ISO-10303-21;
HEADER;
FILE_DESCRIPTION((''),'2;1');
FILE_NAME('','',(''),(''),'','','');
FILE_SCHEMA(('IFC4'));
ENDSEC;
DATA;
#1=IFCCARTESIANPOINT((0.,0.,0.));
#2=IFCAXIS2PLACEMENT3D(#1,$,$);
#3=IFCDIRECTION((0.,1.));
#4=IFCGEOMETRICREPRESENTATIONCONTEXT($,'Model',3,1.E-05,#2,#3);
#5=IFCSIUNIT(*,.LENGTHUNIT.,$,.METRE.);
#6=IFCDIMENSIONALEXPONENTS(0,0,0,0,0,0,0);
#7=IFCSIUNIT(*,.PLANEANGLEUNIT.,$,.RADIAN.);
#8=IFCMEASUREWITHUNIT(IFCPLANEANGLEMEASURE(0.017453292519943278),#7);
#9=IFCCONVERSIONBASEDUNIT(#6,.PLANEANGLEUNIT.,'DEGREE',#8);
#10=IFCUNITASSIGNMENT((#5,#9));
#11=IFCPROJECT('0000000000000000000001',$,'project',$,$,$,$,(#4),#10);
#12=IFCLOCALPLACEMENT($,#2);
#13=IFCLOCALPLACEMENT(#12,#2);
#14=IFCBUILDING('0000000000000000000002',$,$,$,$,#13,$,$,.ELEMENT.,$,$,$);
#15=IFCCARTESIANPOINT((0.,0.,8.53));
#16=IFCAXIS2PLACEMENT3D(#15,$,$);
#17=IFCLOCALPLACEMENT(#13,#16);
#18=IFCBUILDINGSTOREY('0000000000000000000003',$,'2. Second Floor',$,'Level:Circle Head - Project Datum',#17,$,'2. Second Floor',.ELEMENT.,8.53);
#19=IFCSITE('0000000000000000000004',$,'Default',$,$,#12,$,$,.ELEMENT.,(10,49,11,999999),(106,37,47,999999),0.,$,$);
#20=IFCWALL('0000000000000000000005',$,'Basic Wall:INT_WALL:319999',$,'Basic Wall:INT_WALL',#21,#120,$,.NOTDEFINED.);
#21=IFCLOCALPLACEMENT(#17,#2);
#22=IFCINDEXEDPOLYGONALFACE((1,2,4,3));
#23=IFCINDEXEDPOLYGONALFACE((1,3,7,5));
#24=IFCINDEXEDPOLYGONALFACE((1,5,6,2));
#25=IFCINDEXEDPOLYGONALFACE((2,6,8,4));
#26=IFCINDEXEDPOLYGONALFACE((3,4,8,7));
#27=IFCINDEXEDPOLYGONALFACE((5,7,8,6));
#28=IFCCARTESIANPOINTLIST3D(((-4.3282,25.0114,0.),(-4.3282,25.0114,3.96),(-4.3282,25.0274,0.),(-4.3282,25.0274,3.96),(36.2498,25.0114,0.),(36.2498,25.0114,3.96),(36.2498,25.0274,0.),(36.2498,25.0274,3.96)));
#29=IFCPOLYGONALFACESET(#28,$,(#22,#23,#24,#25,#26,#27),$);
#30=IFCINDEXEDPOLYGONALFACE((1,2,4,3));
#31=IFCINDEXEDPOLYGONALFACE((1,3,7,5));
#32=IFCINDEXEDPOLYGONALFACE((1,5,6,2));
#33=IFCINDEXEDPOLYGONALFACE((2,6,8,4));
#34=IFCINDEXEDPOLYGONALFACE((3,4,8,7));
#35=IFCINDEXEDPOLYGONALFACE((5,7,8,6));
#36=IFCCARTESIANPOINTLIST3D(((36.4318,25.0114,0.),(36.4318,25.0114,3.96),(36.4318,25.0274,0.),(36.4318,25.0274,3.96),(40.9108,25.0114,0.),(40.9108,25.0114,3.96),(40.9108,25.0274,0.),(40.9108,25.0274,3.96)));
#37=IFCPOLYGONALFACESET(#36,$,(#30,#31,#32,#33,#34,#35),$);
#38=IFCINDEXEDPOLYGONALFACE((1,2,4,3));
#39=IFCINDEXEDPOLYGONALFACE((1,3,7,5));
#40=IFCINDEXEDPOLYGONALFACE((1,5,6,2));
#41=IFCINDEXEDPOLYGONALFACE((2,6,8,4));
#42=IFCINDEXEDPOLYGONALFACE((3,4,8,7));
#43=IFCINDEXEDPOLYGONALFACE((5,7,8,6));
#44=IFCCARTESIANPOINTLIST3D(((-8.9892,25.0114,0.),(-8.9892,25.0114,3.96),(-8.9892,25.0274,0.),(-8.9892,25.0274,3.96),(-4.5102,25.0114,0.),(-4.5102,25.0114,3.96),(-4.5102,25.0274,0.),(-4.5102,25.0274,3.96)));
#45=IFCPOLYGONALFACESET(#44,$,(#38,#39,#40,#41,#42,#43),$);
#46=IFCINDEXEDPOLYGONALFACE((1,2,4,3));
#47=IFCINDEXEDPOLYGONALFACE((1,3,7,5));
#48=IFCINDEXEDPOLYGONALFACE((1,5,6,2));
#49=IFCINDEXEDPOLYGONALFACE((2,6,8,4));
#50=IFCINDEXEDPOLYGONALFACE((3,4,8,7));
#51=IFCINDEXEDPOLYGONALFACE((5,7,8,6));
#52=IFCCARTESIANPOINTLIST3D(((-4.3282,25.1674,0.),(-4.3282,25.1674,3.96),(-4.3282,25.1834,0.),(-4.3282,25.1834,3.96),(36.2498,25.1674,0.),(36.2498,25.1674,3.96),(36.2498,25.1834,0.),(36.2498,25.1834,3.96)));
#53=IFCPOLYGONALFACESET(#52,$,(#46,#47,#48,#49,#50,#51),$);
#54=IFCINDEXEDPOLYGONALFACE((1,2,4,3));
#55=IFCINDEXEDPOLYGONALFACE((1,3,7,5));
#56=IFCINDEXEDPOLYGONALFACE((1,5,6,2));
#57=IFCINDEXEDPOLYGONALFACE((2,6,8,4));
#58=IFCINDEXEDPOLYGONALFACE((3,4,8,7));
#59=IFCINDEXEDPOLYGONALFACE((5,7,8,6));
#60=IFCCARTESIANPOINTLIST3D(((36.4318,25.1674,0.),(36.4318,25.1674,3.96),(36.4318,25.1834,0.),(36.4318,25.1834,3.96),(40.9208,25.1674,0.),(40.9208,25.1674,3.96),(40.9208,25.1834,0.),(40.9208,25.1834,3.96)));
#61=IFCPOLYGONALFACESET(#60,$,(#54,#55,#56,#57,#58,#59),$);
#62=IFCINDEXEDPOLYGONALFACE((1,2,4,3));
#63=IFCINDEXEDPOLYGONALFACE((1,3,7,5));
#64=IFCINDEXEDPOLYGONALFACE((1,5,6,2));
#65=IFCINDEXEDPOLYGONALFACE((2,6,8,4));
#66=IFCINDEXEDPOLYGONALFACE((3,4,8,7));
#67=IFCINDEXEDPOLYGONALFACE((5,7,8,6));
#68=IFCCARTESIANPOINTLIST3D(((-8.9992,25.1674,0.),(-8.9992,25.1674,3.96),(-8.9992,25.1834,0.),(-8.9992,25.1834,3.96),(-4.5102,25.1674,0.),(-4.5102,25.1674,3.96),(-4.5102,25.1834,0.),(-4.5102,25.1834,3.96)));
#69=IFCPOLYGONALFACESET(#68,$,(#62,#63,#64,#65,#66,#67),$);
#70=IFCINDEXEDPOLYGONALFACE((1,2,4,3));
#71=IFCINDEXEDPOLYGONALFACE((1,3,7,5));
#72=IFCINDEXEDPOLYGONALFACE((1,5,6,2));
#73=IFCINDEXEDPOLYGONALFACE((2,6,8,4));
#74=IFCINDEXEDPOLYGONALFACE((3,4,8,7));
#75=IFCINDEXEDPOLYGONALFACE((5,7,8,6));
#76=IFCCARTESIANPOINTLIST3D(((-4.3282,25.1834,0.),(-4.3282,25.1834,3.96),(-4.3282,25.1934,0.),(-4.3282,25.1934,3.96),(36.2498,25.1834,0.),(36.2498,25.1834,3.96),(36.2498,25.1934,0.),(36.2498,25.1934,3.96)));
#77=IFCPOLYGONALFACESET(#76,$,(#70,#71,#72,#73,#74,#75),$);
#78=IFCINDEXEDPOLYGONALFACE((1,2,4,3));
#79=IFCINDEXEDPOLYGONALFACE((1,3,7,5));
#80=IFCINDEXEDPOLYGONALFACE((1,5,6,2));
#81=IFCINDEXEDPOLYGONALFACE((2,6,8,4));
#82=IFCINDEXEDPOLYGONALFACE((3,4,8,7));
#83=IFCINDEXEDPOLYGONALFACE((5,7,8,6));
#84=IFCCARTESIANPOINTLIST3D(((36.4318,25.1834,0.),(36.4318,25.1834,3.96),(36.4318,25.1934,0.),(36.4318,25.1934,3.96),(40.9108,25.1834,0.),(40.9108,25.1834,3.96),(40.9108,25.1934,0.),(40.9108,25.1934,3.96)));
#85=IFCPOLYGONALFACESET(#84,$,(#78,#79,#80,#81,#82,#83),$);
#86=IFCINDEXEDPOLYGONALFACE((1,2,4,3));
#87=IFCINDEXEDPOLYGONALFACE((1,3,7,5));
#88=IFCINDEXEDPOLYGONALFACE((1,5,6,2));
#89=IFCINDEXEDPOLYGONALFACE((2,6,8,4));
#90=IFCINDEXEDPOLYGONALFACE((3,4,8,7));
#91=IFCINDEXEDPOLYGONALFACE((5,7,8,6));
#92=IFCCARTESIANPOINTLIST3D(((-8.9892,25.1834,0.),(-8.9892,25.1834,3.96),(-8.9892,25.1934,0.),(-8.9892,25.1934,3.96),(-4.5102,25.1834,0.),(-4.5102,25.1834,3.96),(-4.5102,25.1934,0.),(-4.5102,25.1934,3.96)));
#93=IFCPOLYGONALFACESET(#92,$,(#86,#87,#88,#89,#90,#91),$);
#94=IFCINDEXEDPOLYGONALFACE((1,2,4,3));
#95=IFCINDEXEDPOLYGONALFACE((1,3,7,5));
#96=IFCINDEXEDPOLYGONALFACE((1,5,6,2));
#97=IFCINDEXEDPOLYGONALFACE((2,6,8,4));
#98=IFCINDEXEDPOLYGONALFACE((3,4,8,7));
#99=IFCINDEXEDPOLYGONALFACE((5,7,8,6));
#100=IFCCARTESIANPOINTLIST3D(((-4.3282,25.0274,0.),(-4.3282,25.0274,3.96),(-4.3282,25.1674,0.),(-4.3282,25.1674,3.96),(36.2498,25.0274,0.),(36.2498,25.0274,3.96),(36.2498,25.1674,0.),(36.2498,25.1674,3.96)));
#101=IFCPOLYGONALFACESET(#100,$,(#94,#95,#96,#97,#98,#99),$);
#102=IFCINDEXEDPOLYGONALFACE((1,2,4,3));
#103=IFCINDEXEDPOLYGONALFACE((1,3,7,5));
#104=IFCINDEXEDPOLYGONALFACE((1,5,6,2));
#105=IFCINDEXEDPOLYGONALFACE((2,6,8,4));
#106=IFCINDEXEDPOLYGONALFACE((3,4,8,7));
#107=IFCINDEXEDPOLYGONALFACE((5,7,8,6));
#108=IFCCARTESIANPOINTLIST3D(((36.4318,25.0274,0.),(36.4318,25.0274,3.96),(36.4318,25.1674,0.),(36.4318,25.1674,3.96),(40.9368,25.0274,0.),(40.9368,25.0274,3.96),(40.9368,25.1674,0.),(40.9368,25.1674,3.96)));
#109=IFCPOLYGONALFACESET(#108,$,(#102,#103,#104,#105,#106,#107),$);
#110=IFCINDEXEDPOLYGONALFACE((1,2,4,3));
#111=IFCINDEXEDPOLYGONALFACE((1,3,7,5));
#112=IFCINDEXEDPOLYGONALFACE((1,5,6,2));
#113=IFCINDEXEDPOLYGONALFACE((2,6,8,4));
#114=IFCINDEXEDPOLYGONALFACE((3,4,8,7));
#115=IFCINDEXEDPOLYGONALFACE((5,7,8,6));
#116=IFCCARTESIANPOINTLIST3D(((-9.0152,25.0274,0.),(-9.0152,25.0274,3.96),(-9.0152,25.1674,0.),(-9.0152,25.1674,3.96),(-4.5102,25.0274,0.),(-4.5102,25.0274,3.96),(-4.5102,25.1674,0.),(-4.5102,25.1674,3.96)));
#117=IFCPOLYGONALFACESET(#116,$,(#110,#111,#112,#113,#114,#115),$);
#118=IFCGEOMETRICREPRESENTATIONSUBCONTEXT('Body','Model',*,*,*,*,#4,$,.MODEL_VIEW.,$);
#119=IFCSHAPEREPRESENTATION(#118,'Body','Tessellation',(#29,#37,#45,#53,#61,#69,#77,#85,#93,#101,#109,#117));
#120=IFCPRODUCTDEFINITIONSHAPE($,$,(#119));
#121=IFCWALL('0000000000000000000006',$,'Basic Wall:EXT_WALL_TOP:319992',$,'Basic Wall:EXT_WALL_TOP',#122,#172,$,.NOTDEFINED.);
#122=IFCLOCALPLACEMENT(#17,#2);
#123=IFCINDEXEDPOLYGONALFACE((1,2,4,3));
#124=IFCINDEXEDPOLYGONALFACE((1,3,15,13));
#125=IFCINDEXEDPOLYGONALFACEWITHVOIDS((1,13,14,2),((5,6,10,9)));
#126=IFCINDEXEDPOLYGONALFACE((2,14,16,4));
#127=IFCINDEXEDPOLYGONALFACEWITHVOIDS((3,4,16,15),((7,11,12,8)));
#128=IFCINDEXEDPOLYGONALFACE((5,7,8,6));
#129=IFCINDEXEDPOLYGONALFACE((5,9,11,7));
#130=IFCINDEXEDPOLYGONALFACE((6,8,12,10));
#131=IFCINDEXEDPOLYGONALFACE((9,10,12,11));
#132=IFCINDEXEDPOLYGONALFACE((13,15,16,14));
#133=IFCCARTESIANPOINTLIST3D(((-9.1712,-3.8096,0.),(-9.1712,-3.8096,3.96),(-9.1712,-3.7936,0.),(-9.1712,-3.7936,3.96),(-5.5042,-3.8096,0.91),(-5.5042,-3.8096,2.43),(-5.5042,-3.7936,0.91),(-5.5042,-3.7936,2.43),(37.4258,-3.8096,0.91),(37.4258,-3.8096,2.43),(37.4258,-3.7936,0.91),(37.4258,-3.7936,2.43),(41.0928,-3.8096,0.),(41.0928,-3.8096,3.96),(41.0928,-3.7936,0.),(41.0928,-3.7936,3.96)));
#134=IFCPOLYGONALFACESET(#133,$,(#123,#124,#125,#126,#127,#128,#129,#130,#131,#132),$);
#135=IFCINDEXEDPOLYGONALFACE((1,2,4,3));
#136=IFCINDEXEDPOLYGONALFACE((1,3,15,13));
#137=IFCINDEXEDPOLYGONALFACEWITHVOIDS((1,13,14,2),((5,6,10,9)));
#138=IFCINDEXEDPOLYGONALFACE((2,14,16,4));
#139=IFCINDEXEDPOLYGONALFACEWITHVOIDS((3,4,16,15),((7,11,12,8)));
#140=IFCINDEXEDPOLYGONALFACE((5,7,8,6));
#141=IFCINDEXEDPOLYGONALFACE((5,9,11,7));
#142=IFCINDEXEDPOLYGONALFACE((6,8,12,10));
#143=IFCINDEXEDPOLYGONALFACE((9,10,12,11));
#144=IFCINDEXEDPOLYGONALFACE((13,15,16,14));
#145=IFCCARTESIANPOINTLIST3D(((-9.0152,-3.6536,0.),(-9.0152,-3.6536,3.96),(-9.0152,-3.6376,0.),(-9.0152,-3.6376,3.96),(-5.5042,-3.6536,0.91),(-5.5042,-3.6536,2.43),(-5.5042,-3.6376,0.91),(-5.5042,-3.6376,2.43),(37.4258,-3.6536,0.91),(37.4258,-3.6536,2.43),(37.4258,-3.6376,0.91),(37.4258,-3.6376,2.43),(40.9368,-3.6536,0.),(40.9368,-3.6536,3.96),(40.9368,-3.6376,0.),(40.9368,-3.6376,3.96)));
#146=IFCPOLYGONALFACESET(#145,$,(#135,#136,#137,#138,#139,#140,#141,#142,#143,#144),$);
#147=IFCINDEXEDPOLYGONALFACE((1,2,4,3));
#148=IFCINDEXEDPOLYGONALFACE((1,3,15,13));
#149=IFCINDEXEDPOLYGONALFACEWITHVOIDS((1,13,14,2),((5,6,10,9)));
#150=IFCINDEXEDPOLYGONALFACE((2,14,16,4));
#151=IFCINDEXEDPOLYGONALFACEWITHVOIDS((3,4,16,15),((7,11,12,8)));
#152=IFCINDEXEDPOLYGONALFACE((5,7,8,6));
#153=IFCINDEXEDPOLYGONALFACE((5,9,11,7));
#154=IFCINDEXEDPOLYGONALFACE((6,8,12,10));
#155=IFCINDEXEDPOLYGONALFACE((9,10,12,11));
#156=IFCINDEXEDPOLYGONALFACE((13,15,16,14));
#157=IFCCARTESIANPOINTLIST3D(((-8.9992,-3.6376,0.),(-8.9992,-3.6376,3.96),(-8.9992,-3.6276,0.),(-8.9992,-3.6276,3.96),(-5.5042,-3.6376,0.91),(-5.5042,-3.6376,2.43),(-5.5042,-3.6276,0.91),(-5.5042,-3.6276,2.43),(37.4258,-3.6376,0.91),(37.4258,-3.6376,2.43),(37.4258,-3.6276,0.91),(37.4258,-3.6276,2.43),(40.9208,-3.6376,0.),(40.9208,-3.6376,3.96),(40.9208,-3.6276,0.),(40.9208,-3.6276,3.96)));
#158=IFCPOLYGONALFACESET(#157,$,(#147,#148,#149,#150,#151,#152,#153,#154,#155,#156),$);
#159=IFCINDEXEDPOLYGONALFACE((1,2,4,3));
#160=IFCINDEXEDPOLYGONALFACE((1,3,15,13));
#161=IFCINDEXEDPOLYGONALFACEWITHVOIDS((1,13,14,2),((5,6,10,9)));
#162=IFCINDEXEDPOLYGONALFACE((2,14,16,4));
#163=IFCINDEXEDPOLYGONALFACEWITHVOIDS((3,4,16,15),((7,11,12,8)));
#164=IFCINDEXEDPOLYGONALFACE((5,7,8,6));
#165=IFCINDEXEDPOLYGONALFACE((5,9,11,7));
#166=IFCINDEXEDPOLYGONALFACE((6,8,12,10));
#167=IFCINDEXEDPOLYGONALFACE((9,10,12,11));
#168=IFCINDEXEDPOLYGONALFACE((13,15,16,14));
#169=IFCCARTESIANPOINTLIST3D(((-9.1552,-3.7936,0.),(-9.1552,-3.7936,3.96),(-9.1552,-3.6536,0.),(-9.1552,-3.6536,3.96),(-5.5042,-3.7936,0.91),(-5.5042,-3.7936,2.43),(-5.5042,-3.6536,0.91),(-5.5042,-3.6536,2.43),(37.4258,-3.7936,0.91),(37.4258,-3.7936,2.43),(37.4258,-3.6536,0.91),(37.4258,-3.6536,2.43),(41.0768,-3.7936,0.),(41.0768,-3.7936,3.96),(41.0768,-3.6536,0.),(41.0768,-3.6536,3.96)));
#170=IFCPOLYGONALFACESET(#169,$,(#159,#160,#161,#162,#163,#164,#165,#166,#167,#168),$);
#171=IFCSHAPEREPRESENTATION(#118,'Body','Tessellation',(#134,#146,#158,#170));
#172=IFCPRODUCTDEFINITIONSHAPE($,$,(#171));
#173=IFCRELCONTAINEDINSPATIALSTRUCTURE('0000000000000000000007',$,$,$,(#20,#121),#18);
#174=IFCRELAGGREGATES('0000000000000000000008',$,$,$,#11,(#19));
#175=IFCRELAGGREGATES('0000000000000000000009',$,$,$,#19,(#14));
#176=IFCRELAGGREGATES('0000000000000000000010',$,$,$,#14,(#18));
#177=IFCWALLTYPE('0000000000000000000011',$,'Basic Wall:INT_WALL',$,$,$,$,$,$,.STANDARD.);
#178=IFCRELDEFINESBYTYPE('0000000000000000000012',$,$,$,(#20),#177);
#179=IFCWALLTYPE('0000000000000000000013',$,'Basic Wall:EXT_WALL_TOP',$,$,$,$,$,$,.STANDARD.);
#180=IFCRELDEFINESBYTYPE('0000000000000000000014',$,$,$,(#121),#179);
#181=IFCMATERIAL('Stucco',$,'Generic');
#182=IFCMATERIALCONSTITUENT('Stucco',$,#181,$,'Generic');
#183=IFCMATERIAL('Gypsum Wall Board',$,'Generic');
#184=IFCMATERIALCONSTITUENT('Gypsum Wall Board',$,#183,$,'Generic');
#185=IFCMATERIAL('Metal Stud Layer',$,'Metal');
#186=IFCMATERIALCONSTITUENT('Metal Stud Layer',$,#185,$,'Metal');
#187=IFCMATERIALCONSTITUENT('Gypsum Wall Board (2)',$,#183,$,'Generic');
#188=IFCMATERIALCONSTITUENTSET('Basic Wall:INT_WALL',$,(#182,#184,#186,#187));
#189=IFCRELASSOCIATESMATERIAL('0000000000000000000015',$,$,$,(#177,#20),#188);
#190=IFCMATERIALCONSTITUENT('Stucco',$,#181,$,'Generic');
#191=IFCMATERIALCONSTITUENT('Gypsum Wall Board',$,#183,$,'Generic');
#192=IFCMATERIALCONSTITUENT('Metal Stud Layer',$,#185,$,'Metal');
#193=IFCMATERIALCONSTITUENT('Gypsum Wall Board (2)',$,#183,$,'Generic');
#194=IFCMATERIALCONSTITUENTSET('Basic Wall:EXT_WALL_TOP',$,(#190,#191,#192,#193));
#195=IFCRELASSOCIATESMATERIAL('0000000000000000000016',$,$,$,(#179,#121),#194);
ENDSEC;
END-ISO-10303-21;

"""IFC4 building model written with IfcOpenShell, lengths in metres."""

from ifc_helpers import new_model, entity, si_unit, converted_unit, direction, frame, origin, place, context, subcontext, project, spatial, indexed_curve, outline, extrude, material, constituent, constituent_set, type_object, element, save


model = new_model("IFC4")

# Units and contexts
model_context = context("Model", 3, precision=1e-05, world=origin(), true_north=direction((0.0, 1.0)))
body_context = subcontext(model_context, "Body", "Model", "MODEL_VIEW")
ifc_project = project(units=[si_unit("LENGTHUNIT", "METRE"), converted_unit("PLANEANGLEUNIT", "DEGREE", entity("IfcPlaneAngleMeasure", 0.017453292519943278), si_unit("PLANEANGLEUNIT", "RADIAN"), dimensions=[0, 0, 0, 0, 0, 0, 0])], contexts=[model_context])

# Site, building, storey
site_placement = place(None, origin())
site = spatial("IfcSite", under=ifc_project, at=site_placement, Name="Default", CompositionType="ELEMENT", RefLatitude=(10, 49, 11, 999999), RefLongitude=(106, 37, 47, 999999), RefElevation=0.0)
building_placement = place(site_placement, origin())
building = spatial("IfcBuilding", under=site, at=building_placement, CompositionType="ELEMENT")
storey_placement = place(building_placement, frame((0.0, 0.0, 8.53)))
storey = spatial("IfcBuildingStorey", under=building, at=storey_placement, Name="2. Second Floor", ObjectType="Level:Circle Head - Project Datum", LongName="2. Second Floor", CompositionType="ELEMENT", Elevation=8.53)

# Wall
ifc_material_1 = material(Name="Stucco", Category="Generic")
ifc_constituent_1 = constituent(ifc_material_1, Name="Stucco", Category="Generic")
ifc_material_2 = material(Name="Gypsum Wall Board", Category="Generic")
ifc_constituent_2 = constituent(ifc_material_2, Name="Gypsum Wall Board", Category="Generic")
ifc_material_3 = material(Name="Metal Stud Layer", Category="Metal")
ifc_constituent_3 = constituent(ifc_material_3, Name="Metal Stud Layer", Category="Metal")
ifc_constituent_4 = constituent(ifc_material_2, Name="Gypsum Wall Board (2)", Category="Generic")
ifc_constituent_set_1 = constituent_set(constituents=[ifc_constituent_1, ifc_constituent_2, ifc_constituent_3, ifc_constituent_4], Name="Basic Wall:INT_WALL")
wall_type_1 = type_object("IfcWallType", Name="Basic Wall:INT_WALL", PredefinedType="STANDARD", material=ifc_constituent_set_1)
wall_1_placement = place(storey_placement, frame((-8.9892, 25.1024, 0.0)))
element("IfcWall", 1, at=wall_1_placement, inside=storey, type_object=wall_type_1, material=ifc_constituent_set_1, Name="Basic Wall:INT_WALL:319999", ObjectType="Basic Wall:INT_WALL", PredefinedType="NOTDEFINED", context=body_context, shape_type="SweptSolid", body=[
    extrude(outline(indexed_curve([(-0.008, -20.289), (0.008, -20.289), (0.008, 20.289), (-0.008, 20.289), (-0.008, -20.289)], self_intersect=False)), frame((24.95, -0.083, 0.0), z_axis=(0.0, 0.0, 1.0), x_axis=(0.0, 1.0, 0.0)), (0.0, 0.0, 1.0), 3.96),
    extrude(outline(indexed_curve([(-0.008, -2.2395), (0.008, -2.2395), (0.008, 2.2395), (-0.008, 2.2395), (-0.008, -2.2395)], self_intersect=False)), frame((47.6605, -0.083, 0.0), z_axis=(0.0, 0.0, 1.0), x_axis=(0.0, 1.0, 0.0)), (0.0, 0.0, 1.0), 3.96),
    extrude(outline(indexed_curve([(-0.008, -2.2395), (0.008, -2.2395), (0.008, 2.2395), (-0.008, 2.2395), (-0.008, -2.2395)], self_intersect=False)), frame((2.2395, -0.083, 0.0), z_axis=(0.0, 0.0, 1.0), x_axis=(0.0, 1.0, 0.0)), (0.0, 0.0, 1.0), 3.96),
    extrude(outline(indexed_curve([(-20.289, -0.008), (20.289, -0.008), (20.289, 0.008), (-20.289, 0.008), (-20.289, -0.008)], self_intersect=False)), frame((24.95, 0.073, 0.0)), (0.0, 0.0, 1.0), 3.96),
    extrude(outline(indexed_curve([(-2.2445, -0.008), (2.2445, -0.008), (2.2445, 0.008), (-2.2445, 0.008), (-2.2445, -0.008)], self_intersect=False)), frame((47.6655, 0.073, 0.0), z_axis=(0.0, 0.0, 1.0), x_axis=(-1.0, 0.0, 0.0)), (0.0, 0.0, 1.0), 3.96),
    extrude(outline(indexed_curve([(-2.2445, -0.008), (2.2445, -0.008), (2.2445, 0.008), (-2.2445, 0.008), (-2.2445, -0.008)], self_intersect=False)), frame((2.2345, 0.073, 0.0)), (0.0, 0.0, 1.0), 3.96),
    extrude(outline(indexed_curve([(-0.005, -20.289), (0.005, -20.289), (0.005, 20.289), (-0.005, 20.289), (-0.005, -20.289)], self_intersect=False)), frame((24.95, 0.086, 0.0), z_axis=(0.0, 0.0, 1.0), x_axis=(0.0, -1.0, 0.0)), (0.0, 0.0, 1.0), 3.96),
    extrude(outline(indexed_curve([(-0.005, -2.2395), (0.005, -2.2395), (0.005, 2.2395), (-0.005, 2.2395), (-0.005, -2.2395)], self_intersect=False)), frame((47.6605, 0.086, 0.0), z_axis=(0.0, 0.0, 1.0), x_axis=(0.0, -1.0, 0.0)), (0.0, 0.0, 1.0), 3.96),
    extrude(outline(indexed_curve([(-0.005, -2.2395), (0.005, -2.2395), (0.005, 2.2395), (-0.005, 2.2395), (-0.005, -2.2395)], self_intersect=False)), frame((2.2395, 0.086, 0.0), z_axis=(0.0, 0.0, 1.0), x_axis=(0.0, -1.0, 0.0)), (0.0, 0.0, 1.0), 3.96),
    extrude(outline(indexed_curve([(-20.289, -0.07), (20.289, -0.07), (20.289, 0.07), (-20.289, 0.07), (-20.289, -0.07)], self_intersect=False)), frame((24.95, -0.005, 0.0)), (0.0, 0.0, 1.0), 3.96),
    extrude(outline(indexed_curve([(-2.2525, -0.07), (2.2525, -0.07), (2.2525, 0.07), (-2.2525, 0.07), (-2.2525, -0.07)], self_intersect=False)), frame((47.6735, -0.005, 0.0), z_axis=(0.0, 0.0, 1.0), x_axis=(-1.0, 0.0, 0.0)), (0.0, 0.0, 1.0), 3.96),
    extrude(outline(indexed_curve([(-2.2525, -0.07), (2.2525, -0.07), (2.2525, 0.07), (-2.2525, 0.07), (-2.2525, -0.07)], self_intersect=False)), frame((2.2265, -0.005, 0.0)), (0.0, 0.0, 1.0), 3.96),
])

# Wall, opening
ifc_constituent_5 = constituent(ifc_material_1, Name="Stucco", Category="Generic")
ifc_constituent_6 = constituent(ifc_material_2, Name="Gypsum Wall Board", Category="Generic")
ifc_constituent_7 = constituent(ifc_material_3, Name="Metal Stud Layer", Category="Metal")
ifc_constituent_8 = constituent(ifc_material_2, Name="Gypsum Wall Board (2)", Category="Generic")
ifc_constituent_set_2 = constituent_set(constituents=[ifc_constituent_5, ifc_constituent_6, ifc_constituent_7, ifc_constituent_8], Name="Basic Wall:EXT_WALL_TOP")
wall_type_2 = type_object("IfcWallType", Name="Basic Wall:EXT_WALL_TOP", PredefinedType="STANDARD", material=ifc_constituent_set_2)
wall_2_placement = place(storey_placement, frame((-9.1712, -3.7186, 0.0)))
wall_2 = element("IfcWall", 2, at=wall_2_placement, inside=storey, type_object=wall_type_2, material=ifc_constituent_set_2, Name="Basic Wall:EXT_WALL_TOP:319992", ObjectType="Basic Wall:EXT_WALL_TOP", PredefinedType="NOTDEFINED", context=body_context, shape_type="SweptSolid", body=[
    extrude(outline(indexed_curve([(-1.98, -25.132), (1.98, -25.132), (1.98, 25.132), (-1.98, 25.132), (-1.98, -25.132)], self_intersect=False), holes=[indexed_curve([(0.45, 21.465), (0.45, -21.465), (-1.07, -21.465), (-1.07, 21.465), (0.45, 21.465)], self_intersect=False)]), frame((25.132, -0.091, 1.98), z_axis=(0.0, 1.0, 0.0), x_axis=(0.0, 0.0, 1.0)), (0.0, 0.0, 1.0), 0.016),
    extrude(outline(indexed_curve([(-1.98, -24.976), (1.98, -24.976), (1.98, 24.976), (-1.98, 24.976), (-1.98, -24.976)], self_intersect=False), holes=[indexed_curve([(0.45, 21.465), (0.45, -21.465), (-1.07, -21.465), (-1.07, 21.465), (0.45, 21.465)], self_intersect=False)]), frame((25.132, 0.065, 1.98), z_axis=(0.0, 1.0, 0.0), x_axis=(0.0, 0.0, 1.0)), (0.0, 0.0, 1.0), 0.016),
    extrude(outline(indexed_curve([(-1.98, -24.96), (1.98, -24.96), (1.98, 24.96), (-1.98, 24.96), (-1.98, -24.96)], self_intersect=False), holes=[indexed_curve([(0.45, 21.465), (0.45, -21.465), (-1.07, -21.465), (-1.07, 21.465), (0.45, 21.465)], self_intersect=False)]), frame((25.132, 0.081, 1.98), z_axis=(0.0, 1.0, 0.0), x_axis=(0.0, 0.0, 1.0)), (0.0, 0.0, 1.0), 0.01),
    extrude(outline(indexed_curve([(-1.98, -25.116), (1.98, -25.116), (1.98, 25.116), (-1.98, 25.116), (-1.98, -25.116)], self_intersect=False), holes=[indexed_curve([(0.45, 21.465), (0.45, -21.465), (-1.07, -21.465), (-1.07, 21.465), (0.45, 21.465)], self_intersect=False)]), frame((25.132, -0.075, 1.98), z_axis=(0.0, 1.0, 0.0), x_axis=(0.0, 0.0, 1.0)), (0.0, 0.0, 1.0), 0.14),
])
opening_1_placement = place(wall_2_placement, frame((46.597, 0.091, 0.91)))
element("IfcOpeningElement", 3, at=opening_1_placement, cuts=wall_2, PredefinedType="OPENING", context=body_context, shape_type="SweptSolid", body=[
    extrude(outline(indexed_curve([(1.52, 0.0), (1.52, 42.93), (0.0, 42.93), (0.0, 0.0), (1.52, 0.0)], self_intersect=False)), frame((0.0, 0.0, 0.0), z_axis=(0.0, -1.0, 0.0), x_axis=(0.0, 0.0, 1.0)), (0.0, 0.0, 1.0), 0.182),
])

save(model, "model.ifc")
